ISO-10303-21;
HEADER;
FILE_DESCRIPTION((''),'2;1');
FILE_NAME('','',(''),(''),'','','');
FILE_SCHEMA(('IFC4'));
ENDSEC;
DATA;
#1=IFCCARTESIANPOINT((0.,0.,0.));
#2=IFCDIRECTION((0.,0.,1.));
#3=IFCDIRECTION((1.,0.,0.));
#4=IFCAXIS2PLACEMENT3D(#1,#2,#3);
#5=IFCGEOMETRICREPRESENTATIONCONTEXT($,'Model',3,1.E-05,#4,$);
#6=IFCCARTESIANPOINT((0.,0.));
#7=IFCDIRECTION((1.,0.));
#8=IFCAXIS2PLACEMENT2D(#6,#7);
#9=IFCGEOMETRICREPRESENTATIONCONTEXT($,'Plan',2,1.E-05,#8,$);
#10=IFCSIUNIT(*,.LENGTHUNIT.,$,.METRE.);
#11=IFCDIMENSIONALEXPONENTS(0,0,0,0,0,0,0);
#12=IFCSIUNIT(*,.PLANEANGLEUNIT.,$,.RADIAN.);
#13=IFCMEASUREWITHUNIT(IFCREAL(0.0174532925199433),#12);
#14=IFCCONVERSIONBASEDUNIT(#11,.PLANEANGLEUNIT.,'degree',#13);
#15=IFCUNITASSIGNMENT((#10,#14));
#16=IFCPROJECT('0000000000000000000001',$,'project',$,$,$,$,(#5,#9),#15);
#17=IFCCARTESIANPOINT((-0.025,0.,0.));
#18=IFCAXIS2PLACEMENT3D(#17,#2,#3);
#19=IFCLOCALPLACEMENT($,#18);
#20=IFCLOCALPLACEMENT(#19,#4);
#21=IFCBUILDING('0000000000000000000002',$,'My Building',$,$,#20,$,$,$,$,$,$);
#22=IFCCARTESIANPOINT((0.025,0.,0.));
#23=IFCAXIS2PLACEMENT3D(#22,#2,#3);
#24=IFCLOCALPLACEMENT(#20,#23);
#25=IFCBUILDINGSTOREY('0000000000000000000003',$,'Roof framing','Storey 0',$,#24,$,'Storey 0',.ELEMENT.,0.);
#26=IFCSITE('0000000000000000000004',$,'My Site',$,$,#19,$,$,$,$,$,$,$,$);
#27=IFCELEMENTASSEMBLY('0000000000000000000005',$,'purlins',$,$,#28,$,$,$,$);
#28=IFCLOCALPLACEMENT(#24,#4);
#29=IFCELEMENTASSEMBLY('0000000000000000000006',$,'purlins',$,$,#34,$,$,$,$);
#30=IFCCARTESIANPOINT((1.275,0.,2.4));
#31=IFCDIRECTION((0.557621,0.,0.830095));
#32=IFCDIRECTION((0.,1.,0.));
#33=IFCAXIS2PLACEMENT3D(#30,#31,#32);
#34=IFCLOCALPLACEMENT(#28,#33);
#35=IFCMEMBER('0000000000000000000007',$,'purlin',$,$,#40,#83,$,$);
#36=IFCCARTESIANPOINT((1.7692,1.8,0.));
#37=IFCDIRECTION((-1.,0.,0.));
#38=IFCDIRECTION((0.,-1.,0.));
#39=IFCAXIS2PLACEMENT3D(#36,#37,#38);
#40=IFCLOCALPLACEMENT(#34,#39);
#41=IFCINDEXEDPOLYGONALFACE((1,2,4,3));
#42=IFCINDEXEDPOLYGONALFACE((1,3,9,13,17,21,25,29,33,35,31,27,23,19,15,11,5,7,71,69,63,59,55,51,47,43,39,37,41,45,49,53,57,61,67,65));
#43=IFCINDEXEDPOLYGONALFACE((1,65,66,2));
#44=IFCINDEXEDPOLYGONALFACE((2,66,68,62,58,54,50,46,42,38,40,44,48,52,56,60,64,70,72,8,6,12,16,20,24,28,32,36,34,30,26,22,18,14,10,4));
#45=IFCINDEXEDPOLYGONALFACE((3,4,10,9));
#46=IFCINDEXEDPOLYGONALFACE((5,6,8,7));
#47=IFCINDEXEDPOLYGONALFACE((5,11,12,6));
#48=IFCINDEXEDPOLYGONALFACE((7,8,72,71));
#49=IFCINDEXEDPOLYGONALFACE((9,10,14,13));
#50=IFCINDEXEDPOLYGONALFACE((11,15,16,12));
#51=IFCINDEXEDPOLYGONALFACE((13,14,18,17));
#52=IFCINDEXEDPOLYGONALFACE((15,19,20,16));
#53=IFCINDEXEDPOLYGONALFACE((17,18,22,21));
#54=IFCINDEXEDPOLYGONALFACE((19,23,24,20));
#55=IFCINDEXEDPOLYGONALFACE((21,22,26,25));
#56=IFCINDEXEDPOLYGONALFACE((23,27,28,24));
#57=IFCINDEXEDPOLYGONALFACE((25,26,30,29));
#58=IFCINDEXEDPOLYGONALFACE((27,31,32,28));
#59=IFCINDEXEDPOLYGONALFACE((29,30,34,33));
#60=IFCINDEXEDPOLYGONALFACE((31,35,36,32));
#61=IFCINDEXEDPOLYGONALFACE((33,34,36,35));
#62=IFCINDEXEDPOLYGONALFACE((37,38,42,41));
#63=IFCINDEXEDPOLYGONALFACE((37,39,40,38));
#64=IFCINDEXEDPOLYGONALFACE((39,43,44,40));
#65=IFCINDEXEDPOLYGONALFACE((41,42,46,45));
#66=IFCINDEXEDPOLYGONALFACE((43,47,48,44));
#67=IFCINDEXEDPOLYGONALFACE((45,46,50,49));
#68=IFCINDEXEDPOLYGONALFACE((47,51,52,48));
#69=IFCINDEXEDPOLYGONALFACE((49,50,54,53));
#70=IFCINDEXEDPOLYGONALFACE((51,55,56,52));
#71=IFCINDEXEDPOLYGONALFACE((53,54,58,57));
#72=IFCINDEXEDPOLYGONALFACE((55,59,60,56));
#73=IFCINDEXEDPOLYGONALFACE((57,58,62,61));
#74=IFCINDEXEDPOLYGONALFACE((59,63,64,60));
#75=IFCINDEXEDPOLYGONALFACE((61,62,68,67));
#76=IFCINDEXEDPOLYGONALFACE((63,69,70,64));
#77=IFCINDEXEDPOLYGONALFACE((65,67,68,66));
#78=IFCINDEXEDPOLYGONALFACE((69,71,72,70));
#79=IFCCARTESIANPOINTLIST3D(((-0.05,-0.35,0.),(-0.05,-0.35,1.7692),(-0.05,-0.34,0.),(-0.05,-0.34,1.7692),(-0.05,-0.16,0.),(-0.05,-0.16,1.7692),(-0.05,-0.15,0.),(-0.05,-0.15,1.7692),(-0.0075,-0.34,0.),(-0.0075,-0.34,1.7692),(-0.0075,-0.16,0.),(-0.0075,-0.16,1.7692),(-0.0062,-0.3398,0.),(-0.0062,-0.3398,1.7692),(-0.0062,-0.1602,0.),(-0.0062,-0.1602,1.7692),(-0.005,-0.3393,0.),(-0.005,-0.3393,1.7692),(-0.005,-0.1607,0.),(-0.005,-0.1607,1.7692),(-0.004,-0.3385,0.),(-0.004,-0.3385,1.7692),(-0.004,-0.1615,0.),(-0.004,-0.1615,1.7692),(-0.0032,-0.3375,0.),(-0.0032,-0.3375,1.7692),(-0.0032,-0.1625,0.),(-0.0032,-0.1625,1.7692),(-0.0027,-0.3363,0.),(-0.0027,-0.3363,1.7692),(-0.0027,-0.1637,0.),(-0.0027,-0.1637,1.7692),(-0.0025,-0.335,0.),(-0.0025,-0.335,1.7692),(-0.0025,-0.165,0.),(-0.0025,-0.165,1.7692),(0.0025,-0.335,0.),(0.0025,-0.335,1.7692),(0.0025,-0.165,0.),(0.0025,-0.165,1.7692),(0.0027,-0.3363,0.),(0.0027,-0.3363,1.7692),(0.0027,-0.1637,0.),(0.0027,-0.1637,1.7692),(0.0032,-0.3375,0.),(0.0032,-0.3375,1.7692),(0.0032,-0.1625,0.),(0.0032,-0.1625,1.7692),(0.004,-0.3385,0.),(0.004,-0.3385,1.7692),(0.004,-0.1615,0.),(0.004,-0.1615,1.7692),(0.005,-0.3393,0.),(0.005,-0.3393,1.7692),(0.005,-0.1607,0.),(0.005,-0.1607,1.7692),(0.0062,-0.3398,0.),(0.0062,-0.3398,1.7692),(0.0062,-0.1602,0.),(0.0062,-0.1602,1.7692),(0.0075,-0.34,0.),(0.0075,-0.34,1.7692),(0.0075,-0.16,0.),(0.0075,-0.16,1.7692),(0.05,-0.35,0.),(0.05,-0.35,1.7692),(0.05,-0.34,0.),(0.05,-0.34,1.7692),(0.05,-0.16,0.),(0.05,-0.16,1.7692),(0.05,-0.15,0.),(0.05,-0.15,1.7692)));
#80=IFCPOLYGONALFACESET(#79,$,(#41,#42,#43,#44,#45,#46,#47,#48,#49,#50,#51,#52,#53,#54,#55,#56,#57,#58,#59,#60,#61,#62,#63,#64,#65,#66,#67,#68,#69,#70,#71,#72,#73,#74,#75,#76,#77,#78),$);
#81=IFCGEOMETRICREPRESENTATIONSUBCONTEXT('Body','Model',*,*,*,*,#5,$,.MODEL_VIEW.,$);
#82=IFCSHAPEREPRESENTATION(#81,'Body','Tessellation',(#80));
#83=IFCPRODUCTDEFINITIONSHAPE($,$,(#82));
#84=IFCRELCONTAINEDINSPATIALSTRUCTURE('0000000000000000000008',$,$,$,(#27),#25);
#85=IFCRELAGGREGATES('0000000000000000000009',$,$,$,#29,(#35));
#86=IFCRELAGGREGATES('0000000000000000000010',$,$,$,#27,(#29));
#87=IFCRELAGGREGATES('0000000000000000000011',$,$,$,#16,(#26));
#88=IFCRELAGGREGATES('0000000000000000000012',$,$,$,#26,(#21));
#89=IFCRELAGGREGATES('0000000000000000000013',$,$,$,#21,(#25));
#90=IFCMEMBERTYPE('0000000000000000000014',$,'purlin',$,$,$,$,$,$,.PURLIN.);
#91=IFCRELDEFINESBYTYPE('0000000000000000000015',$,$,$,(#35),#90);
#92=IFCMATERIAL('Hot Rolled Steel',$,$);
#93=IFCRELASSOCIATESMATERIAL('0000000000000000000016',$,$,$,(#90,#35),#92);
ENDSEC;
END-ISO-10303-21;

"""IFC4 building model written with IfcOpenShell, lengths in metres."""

from ifc_helpers import new_model, entity, si_unit, converted_unit, frame, frame_2d, origin_with_axes, origin_2d_with_axis, place, context, subcontext, project, spatial, i_section, extrude, material, material_profile, profile_set, profile_usage, type_object, element, aggregate, save


model = new_model("IFC4")

# Units and contexts
model_context = context("Model", 3, precision=1e-05, world=origin_with_axes())
plan_context = context("Plan", 2, precision=1e-05, world=origin_2d_with_axis())
body_context = subcontext(model_context, "Body", "Model", "MODEL_VIEW")
ifc_project = project(units=[si_unit("LENGTHUNIT", "METRE"), converted_unit("PLANEANGLEUNIT", "degree", entity("IfcReal", 0.0174532925199433), si_unit("PLANEANGLEUNIT", "RADIAN"), dimensions=[0, 0, 0, 0, 0, 0, 0])], contexts=[model_context, plan_context])

# Site, building, storey
site_placement = place(None, frame((-0.025, 0.0, 0.0), z_axis=(0.0, 0.0, 1.0), x_axis=(1.0, 0.0, 0.0)))
site = spatial("IfcSite", under=ifc_project, at=site_placement, Name="My Site")
building_placement = place(site_placement, origin_with_axes())
building = spatial("IfcBuilding", under=site, at=building_placement, Name="My Building")
storey_placement = place(building_placement, frame((0.025, 0.0, 0.0), z_axis=(0.0, 0.0, 1.0), x_axis=(1.0, 0.0, 0.0)))
storey = spatial("IfcBuildingStorey", under=building, at=storey_placement, Name="Roof framing", Description="Storey 0", LongName="Storey 0", CompositionType="ELEMENT", Elevation=0.0)

# Element assemblies, member
assembly_1_placement = place(storey_placement, origin_with_axes())
assembly_1 = element("IfcElementAssembly", 1, at=assembly_1_placement, inside=storey, Name="purlins")
assembly_2_placement = place(assembly_1_placement, frame((1.275, 0.0, 2.4), z_axis=(0.557621, 0.0, 0.830095), x_axis=(0.0, 1.0, 0.0)))
assembly_2 = element("IfcElementAssembly", 2, at=assembly_2_placement, Name="purlins")
ifc_material_1 = material(Name="Hot Rolled Steel")
ifc_material_profile_1 = material_profile(ifc_material_1, i_section(OverallWidth=0.1, OverallDepth=0.2, WebThickness=0.005, FlangeThickness=0.01, FilletRadius=0.005, at=frame_2d((0.0, -0.25), x_axis=(1.0, 0.0))))
ifc_profile_set_1 = profile_set([ifc_material_profile_1])
ifc_profile_usage_1 = profile_usage(ifc_profile_set_1)
member_type_1 = type_object("IfcMemberType", Name="purlin", PredefinedType="PURLIN", material=ifc_profile_set_1)
member_1_placement = place(assembly_2_placement, frame((1.7692, 1.8, 0.0), z_axis=(-1.0, 0.0, 0.0), x_axis=(0.0, -1.0, 0.0)))
member_1 = element("IfcMember", 3, at=member_1_placement, type_object=member_type_1, material=ifc_profile_usage_1, Name="purlin", context=body_context, shape_type="SweptSolid", body=[
    extrude(i_section(OverallWidth=0.1, OverallDepth=0.2, WebThickness=0.005, FlangeThickness=0.01, FilletRadius=0.005, at=frame_2d((0.0, -0.25), x_axis=(1.0, 0.0))), origin_with_axes(), (0.0, 0.0, 1.0), 1.7692),
])
aggregate(assembly_2, [member_1])
aggregate(assembly_1, [assembly_2])

save(model, "model.ifc")
